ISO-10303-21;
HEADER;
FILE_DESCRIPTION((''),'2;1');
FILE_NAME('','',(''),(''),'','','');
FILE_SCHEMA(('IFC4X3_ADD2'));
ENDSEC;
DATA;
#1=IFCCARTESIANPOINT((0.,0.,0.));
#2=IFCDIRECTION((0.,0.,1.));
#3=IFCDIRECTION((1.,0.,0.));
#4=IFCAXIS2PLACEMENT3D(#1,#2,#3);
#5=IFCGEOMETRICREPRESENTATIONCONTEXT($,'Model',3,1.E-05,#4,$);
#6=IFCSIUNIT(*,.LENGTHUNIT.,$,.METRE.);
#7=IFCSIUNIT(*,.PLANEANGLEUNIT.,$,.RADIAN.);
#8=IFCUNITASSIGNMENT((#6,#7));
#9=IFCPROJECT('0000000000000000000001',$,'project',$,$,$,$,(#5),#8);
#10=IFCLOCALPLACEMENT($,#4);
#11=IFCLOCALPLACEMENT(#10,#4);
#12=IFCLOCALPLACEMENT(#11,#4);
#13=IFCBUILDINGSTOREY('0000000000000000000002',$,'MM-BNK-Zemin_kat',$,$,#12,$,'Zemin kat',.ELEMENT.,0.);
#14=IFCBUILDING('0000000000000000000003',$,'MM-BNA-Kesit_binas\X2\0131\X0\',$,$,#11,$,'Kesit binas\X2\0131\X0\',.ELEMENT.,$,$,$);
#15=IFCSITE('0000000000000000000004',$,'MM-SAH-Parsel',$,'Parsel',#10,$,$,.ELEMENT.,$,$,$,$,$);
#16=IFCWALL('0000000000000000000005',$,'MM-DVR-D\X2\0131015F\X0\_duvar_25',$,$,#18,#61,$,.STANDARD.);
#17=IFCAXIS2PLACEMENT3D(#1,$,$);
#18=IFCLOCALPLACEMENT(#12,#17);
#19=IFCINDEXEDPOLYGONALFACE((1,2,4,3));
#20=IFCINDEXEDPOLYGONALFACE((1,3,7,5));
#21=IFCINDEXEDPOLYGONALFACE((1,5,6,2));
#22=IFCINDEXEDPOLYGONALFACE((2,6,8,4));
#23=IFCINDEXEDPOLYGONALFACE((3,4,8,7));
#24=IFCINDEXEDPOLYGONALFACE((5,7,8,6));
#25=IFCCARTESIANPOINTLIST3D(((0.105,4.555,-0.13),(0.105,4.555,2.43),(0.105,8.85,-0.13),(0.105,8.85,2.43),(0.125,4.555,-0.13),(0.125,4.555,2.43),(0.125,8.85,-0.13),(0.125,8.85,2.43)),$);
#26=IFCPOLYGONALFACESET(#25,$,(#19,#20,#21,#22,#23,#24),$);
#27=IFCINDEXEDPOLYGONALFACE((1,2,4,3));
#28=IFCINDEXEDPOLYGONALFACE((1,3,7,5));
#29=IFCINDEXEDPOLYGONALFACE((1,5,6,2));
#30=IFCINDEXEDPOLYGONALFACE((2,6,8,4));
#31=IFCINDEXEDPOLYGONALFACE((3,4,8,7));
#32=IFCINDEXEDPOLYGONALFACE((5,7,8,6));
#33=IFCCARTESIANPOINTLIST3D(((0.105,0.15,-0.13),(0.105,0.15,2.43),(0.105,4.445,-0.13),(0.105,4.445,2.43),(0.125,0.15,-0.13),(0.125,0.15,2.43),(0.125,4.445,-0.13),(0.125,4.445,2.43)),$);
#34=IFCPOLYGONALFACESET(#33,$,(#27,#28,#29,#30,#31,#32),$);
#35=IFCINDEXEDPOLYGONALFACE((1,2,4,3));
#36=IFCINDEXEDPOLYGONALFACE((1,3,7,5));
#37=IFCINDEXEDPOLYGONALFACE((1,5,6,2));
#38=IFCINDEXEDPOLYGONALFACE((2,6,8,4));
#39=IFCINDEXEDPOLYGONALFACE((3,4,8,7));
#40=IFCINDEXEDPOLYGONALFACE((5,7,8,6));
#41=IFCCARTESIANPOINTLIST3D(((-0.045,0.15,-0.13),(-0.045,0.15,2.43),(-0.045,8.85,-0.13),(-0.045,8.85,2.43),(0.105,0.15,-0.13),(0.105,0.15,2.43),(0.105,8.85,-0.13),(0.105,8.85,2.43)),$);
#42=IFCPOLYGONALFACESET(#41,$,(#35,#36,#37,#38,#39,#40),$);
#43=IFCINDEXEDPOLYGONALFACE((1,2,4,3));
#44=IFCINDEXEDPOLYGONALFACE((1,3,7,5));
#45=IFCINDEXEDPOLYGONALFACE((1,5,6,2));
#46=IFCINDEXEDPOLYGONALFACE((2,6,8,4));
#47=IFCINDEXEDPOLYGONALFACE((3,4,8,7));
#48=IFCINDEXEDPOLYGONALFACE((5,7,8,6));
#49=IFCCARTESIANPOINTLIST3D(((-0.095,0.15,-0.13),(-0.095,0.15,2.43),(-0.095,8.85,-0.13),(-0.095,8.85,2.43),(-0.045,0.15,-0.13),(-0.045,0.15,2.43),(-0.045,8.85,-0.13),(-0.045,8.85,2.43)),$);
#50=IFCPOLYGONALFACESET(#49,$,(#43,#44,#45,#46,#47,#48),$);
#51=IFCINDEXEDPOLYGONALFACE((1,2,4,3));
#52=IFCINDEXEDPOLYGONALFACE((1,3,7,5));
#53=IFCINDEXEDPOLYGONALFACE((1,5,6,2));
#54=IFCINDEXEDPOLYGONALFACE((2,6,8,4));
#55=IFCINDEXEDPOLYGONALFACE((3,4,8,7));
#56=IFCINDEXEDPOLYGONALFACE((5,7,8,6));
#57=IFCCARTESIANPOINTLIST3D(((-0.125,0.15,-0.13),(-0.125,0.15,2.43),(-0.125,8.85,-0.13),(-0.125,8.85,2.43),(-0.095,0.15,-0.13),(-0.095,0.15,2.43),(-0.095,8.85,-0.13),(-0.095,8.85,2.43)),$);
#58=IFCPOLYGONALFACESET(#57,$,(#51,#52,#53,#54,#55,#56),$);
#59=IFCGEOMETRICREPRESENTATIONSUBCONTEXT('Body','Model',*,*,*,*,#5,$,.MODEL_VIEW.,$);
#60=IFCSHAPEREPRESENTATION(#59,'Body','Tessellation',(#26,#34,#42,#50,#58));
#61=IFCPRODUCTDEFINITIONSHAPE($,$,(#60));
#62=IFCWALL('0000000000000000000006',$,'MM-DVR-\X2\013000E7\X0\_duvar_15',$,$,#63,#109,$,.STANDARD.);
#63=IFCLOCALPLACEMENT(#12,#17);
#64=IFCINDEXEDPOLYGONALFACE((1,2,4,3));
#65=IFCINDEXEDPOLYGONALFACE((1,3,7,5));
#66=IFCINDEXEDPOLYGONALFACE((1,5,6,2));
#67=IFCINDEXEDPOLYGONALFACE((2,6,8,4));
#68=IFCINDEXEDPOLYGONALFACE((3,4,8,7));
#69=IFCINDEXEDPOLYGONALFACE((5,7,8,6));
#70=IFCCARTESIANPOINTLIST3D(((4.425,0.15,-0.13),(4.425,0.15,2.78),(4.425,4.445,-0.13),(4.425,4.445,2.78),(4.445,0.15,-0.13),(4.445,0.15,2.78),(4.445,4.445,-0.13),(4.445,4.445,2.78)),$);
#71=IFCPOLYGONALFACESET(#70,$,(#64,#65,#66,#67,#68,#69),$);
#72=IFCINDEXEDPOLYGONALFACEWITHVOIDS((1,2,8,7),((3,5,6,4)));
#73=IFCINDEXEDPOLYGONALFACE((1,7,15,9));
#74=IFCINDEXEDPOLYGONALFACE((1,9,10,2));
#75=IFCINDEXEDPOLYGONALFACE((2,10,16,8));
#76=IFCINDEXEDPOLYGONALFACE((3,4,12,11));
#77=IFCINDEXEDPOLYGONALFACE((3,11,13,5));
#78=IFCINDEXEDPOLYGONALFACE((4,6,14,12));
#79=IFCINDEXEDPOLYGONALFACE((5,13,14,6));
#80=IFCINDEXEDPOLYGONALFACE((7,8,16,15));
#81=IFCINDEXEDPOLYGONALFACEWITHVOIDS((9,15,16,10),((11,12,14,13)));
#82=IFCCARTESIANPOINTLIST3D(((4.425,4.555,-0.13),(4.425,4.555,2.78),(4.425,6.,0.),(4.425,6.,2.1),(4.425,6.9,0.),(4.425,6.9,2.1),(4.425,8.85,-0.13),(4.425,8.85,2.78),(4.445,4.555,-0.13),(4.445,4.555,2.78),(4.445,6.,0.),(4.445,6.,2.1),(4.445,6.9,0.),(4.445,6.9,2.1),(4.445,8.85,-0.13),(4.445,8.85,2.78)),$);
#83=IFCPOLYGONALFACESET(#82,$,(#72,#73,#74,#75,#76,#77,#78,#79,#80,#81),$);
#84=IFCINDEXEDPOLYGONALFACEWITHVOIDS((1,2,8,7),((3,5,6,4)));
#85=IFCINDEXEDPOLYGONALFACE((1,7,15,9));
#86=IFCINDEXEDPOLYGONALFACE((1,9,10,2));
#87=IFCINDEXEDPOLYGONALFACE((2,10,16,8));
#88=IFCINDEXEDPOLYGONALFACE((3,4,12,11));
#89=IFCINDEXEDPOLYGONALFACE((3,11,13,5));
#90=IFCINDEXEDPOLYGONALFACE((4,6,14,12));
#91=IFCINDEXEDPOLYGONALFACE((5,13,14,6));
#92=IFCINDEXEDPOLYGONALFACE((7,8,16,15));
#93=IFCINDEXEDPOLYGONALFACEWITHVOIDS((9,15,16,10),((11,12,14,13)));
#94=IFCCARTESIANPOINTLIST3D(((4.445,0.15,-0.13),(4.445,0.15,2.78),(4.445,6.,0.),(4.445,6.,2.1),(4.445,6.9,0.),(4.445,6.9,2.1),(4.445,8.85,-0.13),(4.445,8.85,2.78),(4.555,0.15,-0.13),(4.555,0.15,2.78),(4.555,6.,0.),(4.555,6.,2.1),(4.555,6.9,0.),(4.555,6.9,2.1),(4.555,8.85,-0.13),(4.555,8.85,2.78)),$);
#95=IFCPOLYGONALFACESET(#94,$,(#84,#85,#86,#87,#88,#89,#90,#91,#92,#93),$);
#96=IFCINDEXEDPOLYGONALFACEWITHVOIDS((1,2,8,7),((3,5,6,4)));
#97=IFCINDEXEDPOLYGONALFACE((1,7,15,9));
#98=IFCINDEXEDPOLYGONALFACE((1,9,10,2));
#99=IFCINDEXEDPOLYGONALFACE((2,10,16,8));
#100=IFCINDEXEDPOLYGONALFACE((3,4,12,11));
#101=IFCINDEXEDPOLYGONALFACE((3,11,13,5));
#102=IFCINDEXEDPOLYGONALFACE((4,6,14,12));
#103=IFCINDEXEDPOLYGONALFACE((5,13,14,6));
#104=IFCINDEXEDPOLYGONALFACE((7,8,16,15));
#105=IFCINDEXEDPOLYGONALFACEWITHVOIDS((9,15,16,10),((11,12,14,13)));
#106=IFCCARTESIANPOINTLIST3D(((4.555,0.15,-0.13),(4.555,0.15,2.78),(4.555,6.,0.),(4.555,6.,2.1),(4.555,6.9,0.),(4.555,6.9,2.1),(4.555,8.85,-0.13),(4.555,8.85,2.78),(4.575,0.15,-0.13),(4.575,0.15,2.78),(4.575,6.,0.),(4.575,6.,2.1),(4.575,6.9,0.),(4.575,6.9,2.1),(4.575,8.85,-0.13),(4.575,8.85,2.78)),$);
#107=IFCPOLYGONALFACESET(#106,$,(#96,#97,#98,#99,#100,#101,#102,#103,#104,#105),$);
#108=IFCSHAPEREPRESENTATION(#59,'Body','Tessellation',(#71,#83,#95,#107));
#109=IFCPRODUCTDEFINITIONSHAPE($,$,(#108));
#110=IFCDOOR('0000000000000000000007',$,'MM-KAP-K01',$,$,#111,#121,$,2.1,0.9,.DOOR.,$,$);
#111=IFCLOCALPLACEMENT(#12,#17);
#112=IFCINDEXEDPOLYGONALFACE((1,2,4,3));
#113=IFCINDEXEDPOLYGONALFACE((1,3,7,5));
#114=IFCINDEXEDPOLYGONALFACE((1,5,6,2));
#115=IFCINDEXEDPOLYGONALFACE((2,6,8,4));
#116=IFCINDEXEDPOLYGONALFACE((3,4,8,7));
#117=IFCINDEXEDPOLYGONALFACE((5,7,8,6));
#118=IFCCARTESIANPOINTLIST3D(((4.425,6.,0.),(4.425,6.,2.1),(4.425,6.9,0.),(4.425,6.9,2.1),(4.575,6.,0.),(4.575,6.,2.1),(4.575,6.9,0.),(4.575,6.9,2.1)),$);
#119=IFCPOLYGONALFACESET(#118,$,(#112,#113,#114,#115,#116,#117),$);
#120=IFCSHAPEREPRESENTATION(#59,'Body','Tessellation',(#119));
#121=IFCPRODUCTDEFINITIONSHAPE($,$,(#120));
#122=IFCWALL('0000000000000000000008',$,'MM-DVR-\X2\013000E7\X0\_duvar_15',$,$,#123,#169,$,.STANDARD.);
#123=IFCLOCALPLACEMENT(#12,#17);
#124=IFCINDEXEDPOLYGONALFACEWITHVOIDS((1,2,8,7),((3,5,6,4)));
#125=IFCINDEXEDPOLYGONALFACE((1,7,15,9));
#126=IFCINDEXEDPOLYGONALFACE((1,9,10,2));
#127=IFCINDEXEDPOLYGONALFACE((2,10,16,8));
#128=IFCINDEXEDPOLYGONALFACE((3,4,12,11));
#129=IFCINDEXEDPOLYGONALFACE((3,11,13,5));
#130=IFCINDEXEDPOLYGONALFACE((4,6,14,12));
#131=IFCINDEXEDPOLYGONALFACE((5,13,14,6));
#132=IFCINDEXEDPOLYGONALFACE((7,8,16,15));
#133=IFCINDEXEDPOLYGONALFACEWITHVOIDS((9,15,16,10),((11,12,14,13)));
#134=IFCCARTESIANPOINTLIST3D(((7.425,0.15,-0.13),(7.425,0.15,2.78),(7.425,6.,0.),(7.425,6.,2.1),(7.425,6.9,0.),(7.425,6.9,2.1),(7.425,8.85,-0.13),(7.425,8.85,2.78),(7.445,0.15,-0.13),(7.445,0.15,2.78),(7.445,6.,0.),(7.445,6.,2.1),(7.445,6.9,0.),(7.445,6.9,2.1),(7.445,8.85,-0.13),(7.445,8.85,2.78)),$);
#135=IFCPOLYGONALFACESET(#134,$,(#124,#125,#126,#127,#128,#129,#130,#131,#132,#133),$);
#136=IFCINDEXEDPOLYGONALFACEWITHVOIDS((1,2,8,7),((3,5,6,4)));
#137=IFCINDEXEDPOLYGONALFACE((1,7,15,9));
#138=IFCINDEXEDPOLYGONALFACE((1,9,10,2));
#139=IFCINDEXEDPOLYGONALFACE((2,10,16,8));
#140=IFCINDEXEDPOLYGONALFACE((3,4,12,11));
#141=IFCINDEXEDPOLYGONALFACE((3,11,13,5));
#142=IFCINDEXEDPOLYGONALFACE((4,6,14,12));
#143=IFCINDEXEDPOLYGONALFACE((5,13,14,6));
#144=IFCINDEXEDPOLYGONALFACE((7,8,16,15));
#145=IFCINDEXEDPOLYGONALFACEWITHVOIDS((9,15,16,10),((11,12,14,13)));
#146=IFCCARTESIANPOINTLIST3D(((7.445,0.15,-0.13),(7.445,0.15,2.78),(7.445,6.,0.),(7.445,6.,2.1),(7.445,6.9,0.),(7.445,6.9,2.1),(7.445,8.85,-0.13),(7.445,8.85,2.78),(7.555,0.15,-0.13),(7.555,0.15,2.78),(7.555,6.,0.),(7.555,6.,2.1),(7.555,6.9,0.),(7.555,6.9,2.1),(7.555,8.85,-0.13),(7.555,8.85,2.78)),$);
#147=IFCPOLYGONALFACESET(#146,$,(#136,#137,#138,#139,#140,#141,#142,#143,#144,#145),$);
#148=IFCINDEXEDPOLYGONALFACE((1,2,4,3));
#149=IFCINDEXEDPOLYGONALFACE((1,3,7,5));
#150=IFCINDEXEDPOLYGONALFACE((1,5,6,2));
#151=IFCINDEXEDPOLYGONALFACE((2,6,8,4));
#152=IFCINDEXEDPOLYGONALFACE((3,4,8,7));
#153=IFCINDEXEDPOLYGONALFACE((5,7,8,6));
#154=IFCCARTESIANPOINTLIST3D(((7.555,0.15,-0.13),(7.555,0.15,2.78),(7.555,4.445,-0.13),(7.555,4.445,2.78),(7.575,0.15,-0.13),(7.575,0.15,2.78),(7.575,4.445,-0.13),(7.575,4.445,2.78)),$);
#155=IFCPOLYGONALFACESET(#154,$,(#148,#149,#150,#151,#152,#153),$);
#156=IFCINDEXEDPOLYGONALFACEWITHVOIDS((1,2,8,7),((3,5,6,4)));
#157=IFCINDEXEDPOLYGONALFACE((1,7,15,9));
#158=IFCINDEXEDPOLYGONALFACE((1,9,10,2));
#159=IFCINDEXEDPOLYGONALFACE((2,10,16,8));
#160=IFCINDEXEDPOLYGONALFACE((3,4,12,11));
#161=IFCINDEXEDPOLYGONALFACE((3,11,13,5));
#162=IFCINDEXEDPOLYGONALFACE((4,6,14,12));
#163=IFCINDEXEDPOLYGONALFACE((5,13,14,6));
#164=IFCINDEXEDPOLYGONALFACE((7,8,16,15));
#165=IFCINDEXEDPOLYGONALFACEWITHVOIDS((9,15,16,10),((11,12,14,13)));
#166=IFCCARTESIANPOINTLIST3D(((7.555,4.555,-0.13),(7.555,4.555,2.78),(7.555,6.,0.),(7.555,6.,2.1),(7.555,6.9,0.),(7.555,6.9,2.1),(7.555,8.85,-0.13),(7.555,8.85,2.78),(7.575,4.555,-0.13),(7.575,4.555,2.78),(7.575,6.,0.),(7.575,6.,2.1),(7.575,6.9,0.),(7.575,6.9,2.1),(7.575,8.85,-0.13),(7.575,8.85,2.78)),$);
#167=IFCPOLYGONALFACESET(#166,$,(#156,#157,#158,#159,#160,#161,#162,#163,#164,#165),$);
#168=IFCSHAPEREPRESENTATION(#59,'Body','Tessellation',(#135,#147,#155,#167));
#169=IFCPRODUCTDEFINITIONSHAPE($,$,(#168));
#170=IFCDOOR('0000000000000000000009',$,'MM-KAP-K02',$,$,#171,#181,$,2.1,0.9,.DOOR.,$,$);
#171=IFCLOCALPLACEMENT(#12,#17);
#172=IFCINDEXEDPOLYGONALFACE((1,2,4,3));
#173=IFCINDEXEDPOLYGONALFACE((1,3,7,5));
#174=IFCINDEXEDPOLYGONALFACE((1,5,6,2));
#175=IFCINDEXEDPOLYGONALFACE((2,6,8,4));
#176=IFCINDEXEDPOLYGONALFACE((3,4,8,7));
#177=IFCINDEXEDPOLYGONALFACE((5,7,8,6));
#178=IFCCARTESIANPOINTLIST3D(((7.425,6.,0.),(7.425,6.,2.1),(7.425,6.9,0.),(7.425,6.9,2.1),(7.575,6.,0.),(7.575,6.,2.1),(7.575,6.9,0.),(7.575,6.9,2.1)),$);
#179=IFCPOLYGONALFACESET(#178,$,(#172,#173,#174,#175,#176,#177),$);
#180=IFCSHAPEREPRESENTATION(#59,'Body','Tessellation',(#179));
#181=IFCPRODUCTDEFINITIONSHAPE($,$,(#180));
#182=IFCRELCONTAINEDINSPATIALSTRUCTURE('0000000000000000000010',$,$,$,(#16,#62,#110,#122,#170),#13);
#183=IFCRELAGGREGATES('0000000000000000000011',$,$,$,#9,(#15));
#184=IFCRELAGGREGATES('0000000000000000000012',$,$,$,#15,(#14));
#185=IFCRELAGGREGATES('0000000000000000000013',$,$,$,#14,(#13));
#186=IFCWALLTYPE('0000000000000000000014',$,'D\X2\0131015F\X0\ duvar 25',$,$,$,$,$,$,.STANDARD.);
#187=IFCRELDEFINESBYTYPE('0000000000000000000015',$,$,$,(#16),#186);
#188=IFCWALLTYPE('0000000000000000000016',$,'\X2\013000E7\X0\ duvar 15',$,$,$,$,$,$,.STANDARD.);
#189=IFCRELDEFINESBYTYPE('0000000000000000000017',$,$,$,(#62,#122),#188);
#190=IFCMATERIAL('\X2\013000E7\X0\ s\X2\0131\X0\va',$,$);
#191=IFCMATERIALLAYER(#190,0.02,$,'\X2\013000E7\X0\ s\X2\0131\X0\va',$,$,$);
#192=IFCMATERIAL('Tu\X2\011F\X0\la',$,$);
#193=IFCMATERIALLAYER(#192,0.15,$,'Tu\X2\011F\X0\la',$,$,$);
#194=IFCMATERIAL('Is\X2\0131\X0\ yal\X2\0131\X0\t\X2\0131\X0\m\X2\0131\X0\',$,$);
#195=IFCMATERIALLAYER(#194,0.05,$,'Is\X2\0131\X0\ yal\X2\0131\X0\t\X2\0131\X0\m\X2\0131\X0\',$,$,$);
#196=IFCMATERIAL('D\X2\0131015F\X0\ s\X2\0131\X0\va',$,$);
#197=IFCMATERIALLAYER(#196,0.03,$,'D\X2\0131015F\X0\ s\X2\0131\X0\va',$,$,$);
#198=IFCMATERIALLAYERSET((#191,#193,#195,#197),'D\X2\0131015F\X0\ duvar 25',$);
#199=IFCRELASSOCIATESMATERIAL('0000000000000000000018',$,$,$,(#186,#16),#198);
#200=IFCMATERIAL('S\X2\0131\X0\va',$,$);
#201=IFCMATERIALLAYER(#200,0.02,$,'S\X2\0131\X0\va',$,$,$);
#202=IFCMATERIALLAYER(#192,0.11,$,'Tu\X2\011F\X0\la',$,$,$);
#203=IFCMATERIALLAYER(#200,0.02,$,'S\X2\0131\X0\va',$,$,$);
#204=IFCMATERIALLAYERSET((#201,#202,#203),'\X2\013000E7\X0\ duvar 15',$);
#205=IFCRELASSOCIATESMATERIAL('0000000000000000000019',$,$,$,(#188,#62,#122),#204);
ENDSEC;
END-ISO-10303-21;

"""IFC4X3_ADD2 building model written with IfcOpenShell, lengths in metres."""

from ifc_helpers import new_model, si_unit, frame, origin, origin_with_axes, place, context, subcontext, project, spatial, polyline, outline, extrude, material, layer, layer_set, type_object, element, fill, save


model = new_model("IFC4X3_ADD2")

# Units and contexts
model_context = context("Model", 3, precision=1e-05, world=origin_with_axes())
body_context = subcontext(model_context, "Body", "Model", "MODEL_VIEW")
ifc_project = project(units=[si_unit("LENGTHUNIT", "METRE"), si_unit("PLANEANGLEUNIT", "RADIAN")], contexts=[model_context])

# Site, building, storey
site_placement = place(None, origin_with_axes())
site = spatial("IfcSite", under=ifc_project, at=site_placement, Name="MM-SAH-Parsel", ObjectType="Parsel", CompositionType="ELEMENT")
building_placement = place(site_placement, origin_with_axes())
building = spatial("IfcBuilding", under=site, at=building_placement, Name="MM-BNA-Kesit_binası", LongName="Kesit binası", CompositionType="ELEMENT")
storey_placement = place(building_placement, origin_with_axes())
storey = spatial("IfcBuildingStorey", under=building, at=storey_placement, Name="MM-BNK-Zemin_kat", LongName="Zemin kat", CompositionType="ELEMENT", Elevation=0.0)

# Shared definitions
ifc_material_1 = material(Name="İç sıva")
ifc_layer_1 = layer(ifc_material_1, 0.02, Name="İç sıva")
ifc_material_2 = material(Name="Tuğla")
ifc_layer_2 = layer(ifc_material_2, 0.15, Name="Tuğla")
ifc_material_3 = material(Name="Isı yalıtımı")
ifc_layer_3 = layer(ifc_material_3, 0.05, Name="Isı yalıtımı")
ifc_material_4 = material(Name="Dış sıva")
ifc_layer_4 = layer(ifc_material_4, 0.03, Name="Dış sıva")
ifc_layer_set_1 = layer_set([ifc_layer_1, ifc_layer_2, ifc_layer_3, ifc_layer_4], Name="Dış duvar 25")
wall_type_1 = type_object("IfcWallType", Name="Dış duvar 25", PredefinedType="STANDARD", material=ifc_layer_set_1)

# Wall
wall_1_placement = place(storey_placement, origin_with_axes())
element("IfcWall", 1, at=wall_1_placement, inside=storey, type_object=wall_type_1, material=ifc_layer_set_1, Name="MM-DVR-Dış_duvar_25", PredefinedType="STANDARD", context=body_context, shape_type="SweptSolid", body=[
    extrude(outline(polyline([(0.105, 8.85), (0.105, 4.555), (0.125, 4.555), (0.125, 8.85), (0.105, 8.85)])), frame((0.0, 0.0, -0.13)), (0.0, 0.0, 1.0), 2.56),
    extrude(outline(polyline([(0.105, 4.445), (0.105, 0.15), (0.125, 0.15), (0.125, 4.445), (0.105, 4.445)])), frame((0.0, 0.0, -0.13)), (0.0, 0.0, 1.0), 2.56),
    extrude(outline(polyline([(-0.045, 8.85), (-0.045, 0.15), (0.105, 0.15), (0.105, 8.85), (-0.045, 8.85)])), frame((0.0, 0.0, -0.13)), (0.0, 0.0, 1.0), 2.56),
    extrude(outline(polyline([(-0.095, 8.85), (-0.095, 0.15), (-0.045, 0.15), (-0.045, 8.85), (-0.095, 8.85)])), frame((0.0, 0.0, -0.13)), (0.0, 0.0, 1.0), 2.56),
    extrude(outline(polyline([(-0.125, 8.85), (-0.125, 0.15), (-0.095, 0.15), (-0.095, 8.85), (-0.125, 8.85)])), frame((0.0, 0.0, -0.13)), (0.0, 0.0, 1.0), 2.56),
])

# Walls, openings, doors
ifc_material_5 = material(Name="Sıva")
ifc_layer_5 = layer(ifc_material_5, 0.02, Name="Sıva")
ifc_layer_6 = layer(ifc_material_2, 0.11, Name="Tuğla")
ifc_layer_7 = layer(ifc_material_5, 0.02, Name="Sıva")
ifc_layer_set_2 = layer_set([ifc_layer_5, ifc_layer_6, ifc_layer_7], Name="İç duvar 15")
wall_type_2 = type_object("IfcWallType", Name="İç duvar 15", PredefinedType="STANDARD", material=ifc_layer_set_2)
wall_2_placement = place(storey_placement, origin_with_axes())
wall_2 = element("IfcWall", 2, at=wall_2_placement, inside=storey, type_object=wall_type_2, material=ifc_layer_set_2, Name="MM-DVR-İç_duvar_15", PredefinedType="STANDARD", context=body_context, shape_type="SweptSolid", body=[
    extrude(outline(polyline([(4.445, 0.15), (4.445, 4.445), (4.425, 4.445), (4.425, 0.15), (4.445, 0.15)])), frame((0.0, 0.0, -0.13)), (0.0, 0.0, 1.0), 2.91),
    extrude(outline(polyline([(4.445, 4.555), (4.445, 8.85), (4.425, 8.85), (4.425, 4.555), (4.445, 4.555)])), frame((0.0, 0.0, -0.13)), (0.0, 0.0, 1.0), 2.91),
    extrude(outline(polyline([(4.555, 0.15), (4.555, 8.85), (4.445, 8.85), (4.445, 0.15), (4.555, 0.15)])), frame((0.0, 0.0, -0.13)), (0.0, 0.0, 1.0), 2.91),
    extrude(outline(polyline([(4.575, 0.15), (4.575, 8.85), (4.555, 8.85), (4.555, 0.15), (4.575, 0.15)])), frame((0.0, 0.0, -0.13)), (0.0, 0.0, 1.0), 2.91),
])
opening_1_placement = place(storey_placement, origin_with_axes())
opening_1 = element("IfcOpeningElement", 3, at=opening_1_placement, cuts=wall_2, PredefinedType="OPENING", context=body_context, shape_type="SweptSolid", body=[
    extrude(outline(polyline([(4.425, 6.0), (4.425, 6.9), (4.575, 6.9), (4.575, 6.0), (4.425, 6.0)])), origin(), (0.0, 0.0, 1.0), 2.1),
])
door_1_placement = place(storey_placement, origin_with_axes())
door_1 = element("IfcDoor", 4, at=door_1_placement, inside=storey, Name="MM-KAP-K01", OverallHeight=2.1, OverallWidth=0.9, PredefinedType="DOOR", context=body_context, shape_type="SweptSolid", body=[
    extrude(outline(polyline([(4.425, 6.0), (4.425, 6.9), (4.575, 6.9), (4.575, 6.0), (4.425, 6.0)])), origin(), (0.0, 0.0, 1.0), 2.1),
])
fill(opening_1, door_1)
wall_3_placement = place(storey_placement, origin_with_axes())
wall_3 = element("IfcWall", 5, at=wall_3_placement, inside=storey, type_object=wall_type_2, material=ifc_layer_set_2, Name="MM-DVR-İç_duvar_15", PredefinedType="STANDARD", context=body_context, shape_type="SweptSolid", body=[
    extrude(outline(polyline([(7.445, 0.15), (7.445, 8.85), (7.425, 8.85), (7.425, 0.15), (7.445, 0.15)])), frame((0.0, 0.0, -0.13)), (0.0, 0.0, 1.0), 2.91),
    extrude(outline(polyline([(7.555, 0.15), (7.555, 8.85), (7.445, 8.85), (7.445, 0.15), (7.555, 0.15)])), frame((0.0, 0.0, -0.13)), (0.0, 0.0, 1.0), 2.91),
    extrude(outline(polyline([(7.575, 0.15), (7.575, 4.445), (7.555, 4.445), (7.555, 0.15), (7.575, 0.15)])), frame((0.0, 0.0, -0.13)), (0.0, 0.0, 1.0), 2.91),
    extrude(outline(polyline([(7.575, 4.555), (7.575, 8.85), (7.555, 8.85), (7.555, 4.555), (7.575, 4.555)])), frame((0.0, 0.0, -0.13)), (0.0, 0.0, 1.0), 2.91),
])
opening_2_placement = place(storey_placement, origin_with_axes())
opening_2 = element("IfcOpeningElement", 6, at=opening_2_placement, cuts=wall_3, PredefinedType="OPENING", context=body_context, shape_type="SweptSolid", body=[
    extrude(outline(polyline([(7.425, 6.0), (7.425, 6.9), (7.575, 6.9), (7.575, 6.0), (7.425, 6.0)])), origin(), (0.0, 0.0, 1.0), 2.1),
])
door_2_placement = place(storey_placement, origin_with_axes())
door_2 = element("IfcDoor", 7, at=door_2_placement, inside=storey, Name="MM-KAP-K02", OverallHeight=2.1, OverallWidth=0.9, PredefinedType="DOOR", context=body_context, shape_type="SweptSolid", body=[
    extrude(outline(polyline([(7.425, 6.0), (7.425, 6.9), (7.575, 6.9), (7.575, 6.0), (7.425, 6.0)])), origin(), (0.0, 0.0, 1.0), 2.1),
])
fill(opening_2, door_2)

save(model, "model.ifc")
